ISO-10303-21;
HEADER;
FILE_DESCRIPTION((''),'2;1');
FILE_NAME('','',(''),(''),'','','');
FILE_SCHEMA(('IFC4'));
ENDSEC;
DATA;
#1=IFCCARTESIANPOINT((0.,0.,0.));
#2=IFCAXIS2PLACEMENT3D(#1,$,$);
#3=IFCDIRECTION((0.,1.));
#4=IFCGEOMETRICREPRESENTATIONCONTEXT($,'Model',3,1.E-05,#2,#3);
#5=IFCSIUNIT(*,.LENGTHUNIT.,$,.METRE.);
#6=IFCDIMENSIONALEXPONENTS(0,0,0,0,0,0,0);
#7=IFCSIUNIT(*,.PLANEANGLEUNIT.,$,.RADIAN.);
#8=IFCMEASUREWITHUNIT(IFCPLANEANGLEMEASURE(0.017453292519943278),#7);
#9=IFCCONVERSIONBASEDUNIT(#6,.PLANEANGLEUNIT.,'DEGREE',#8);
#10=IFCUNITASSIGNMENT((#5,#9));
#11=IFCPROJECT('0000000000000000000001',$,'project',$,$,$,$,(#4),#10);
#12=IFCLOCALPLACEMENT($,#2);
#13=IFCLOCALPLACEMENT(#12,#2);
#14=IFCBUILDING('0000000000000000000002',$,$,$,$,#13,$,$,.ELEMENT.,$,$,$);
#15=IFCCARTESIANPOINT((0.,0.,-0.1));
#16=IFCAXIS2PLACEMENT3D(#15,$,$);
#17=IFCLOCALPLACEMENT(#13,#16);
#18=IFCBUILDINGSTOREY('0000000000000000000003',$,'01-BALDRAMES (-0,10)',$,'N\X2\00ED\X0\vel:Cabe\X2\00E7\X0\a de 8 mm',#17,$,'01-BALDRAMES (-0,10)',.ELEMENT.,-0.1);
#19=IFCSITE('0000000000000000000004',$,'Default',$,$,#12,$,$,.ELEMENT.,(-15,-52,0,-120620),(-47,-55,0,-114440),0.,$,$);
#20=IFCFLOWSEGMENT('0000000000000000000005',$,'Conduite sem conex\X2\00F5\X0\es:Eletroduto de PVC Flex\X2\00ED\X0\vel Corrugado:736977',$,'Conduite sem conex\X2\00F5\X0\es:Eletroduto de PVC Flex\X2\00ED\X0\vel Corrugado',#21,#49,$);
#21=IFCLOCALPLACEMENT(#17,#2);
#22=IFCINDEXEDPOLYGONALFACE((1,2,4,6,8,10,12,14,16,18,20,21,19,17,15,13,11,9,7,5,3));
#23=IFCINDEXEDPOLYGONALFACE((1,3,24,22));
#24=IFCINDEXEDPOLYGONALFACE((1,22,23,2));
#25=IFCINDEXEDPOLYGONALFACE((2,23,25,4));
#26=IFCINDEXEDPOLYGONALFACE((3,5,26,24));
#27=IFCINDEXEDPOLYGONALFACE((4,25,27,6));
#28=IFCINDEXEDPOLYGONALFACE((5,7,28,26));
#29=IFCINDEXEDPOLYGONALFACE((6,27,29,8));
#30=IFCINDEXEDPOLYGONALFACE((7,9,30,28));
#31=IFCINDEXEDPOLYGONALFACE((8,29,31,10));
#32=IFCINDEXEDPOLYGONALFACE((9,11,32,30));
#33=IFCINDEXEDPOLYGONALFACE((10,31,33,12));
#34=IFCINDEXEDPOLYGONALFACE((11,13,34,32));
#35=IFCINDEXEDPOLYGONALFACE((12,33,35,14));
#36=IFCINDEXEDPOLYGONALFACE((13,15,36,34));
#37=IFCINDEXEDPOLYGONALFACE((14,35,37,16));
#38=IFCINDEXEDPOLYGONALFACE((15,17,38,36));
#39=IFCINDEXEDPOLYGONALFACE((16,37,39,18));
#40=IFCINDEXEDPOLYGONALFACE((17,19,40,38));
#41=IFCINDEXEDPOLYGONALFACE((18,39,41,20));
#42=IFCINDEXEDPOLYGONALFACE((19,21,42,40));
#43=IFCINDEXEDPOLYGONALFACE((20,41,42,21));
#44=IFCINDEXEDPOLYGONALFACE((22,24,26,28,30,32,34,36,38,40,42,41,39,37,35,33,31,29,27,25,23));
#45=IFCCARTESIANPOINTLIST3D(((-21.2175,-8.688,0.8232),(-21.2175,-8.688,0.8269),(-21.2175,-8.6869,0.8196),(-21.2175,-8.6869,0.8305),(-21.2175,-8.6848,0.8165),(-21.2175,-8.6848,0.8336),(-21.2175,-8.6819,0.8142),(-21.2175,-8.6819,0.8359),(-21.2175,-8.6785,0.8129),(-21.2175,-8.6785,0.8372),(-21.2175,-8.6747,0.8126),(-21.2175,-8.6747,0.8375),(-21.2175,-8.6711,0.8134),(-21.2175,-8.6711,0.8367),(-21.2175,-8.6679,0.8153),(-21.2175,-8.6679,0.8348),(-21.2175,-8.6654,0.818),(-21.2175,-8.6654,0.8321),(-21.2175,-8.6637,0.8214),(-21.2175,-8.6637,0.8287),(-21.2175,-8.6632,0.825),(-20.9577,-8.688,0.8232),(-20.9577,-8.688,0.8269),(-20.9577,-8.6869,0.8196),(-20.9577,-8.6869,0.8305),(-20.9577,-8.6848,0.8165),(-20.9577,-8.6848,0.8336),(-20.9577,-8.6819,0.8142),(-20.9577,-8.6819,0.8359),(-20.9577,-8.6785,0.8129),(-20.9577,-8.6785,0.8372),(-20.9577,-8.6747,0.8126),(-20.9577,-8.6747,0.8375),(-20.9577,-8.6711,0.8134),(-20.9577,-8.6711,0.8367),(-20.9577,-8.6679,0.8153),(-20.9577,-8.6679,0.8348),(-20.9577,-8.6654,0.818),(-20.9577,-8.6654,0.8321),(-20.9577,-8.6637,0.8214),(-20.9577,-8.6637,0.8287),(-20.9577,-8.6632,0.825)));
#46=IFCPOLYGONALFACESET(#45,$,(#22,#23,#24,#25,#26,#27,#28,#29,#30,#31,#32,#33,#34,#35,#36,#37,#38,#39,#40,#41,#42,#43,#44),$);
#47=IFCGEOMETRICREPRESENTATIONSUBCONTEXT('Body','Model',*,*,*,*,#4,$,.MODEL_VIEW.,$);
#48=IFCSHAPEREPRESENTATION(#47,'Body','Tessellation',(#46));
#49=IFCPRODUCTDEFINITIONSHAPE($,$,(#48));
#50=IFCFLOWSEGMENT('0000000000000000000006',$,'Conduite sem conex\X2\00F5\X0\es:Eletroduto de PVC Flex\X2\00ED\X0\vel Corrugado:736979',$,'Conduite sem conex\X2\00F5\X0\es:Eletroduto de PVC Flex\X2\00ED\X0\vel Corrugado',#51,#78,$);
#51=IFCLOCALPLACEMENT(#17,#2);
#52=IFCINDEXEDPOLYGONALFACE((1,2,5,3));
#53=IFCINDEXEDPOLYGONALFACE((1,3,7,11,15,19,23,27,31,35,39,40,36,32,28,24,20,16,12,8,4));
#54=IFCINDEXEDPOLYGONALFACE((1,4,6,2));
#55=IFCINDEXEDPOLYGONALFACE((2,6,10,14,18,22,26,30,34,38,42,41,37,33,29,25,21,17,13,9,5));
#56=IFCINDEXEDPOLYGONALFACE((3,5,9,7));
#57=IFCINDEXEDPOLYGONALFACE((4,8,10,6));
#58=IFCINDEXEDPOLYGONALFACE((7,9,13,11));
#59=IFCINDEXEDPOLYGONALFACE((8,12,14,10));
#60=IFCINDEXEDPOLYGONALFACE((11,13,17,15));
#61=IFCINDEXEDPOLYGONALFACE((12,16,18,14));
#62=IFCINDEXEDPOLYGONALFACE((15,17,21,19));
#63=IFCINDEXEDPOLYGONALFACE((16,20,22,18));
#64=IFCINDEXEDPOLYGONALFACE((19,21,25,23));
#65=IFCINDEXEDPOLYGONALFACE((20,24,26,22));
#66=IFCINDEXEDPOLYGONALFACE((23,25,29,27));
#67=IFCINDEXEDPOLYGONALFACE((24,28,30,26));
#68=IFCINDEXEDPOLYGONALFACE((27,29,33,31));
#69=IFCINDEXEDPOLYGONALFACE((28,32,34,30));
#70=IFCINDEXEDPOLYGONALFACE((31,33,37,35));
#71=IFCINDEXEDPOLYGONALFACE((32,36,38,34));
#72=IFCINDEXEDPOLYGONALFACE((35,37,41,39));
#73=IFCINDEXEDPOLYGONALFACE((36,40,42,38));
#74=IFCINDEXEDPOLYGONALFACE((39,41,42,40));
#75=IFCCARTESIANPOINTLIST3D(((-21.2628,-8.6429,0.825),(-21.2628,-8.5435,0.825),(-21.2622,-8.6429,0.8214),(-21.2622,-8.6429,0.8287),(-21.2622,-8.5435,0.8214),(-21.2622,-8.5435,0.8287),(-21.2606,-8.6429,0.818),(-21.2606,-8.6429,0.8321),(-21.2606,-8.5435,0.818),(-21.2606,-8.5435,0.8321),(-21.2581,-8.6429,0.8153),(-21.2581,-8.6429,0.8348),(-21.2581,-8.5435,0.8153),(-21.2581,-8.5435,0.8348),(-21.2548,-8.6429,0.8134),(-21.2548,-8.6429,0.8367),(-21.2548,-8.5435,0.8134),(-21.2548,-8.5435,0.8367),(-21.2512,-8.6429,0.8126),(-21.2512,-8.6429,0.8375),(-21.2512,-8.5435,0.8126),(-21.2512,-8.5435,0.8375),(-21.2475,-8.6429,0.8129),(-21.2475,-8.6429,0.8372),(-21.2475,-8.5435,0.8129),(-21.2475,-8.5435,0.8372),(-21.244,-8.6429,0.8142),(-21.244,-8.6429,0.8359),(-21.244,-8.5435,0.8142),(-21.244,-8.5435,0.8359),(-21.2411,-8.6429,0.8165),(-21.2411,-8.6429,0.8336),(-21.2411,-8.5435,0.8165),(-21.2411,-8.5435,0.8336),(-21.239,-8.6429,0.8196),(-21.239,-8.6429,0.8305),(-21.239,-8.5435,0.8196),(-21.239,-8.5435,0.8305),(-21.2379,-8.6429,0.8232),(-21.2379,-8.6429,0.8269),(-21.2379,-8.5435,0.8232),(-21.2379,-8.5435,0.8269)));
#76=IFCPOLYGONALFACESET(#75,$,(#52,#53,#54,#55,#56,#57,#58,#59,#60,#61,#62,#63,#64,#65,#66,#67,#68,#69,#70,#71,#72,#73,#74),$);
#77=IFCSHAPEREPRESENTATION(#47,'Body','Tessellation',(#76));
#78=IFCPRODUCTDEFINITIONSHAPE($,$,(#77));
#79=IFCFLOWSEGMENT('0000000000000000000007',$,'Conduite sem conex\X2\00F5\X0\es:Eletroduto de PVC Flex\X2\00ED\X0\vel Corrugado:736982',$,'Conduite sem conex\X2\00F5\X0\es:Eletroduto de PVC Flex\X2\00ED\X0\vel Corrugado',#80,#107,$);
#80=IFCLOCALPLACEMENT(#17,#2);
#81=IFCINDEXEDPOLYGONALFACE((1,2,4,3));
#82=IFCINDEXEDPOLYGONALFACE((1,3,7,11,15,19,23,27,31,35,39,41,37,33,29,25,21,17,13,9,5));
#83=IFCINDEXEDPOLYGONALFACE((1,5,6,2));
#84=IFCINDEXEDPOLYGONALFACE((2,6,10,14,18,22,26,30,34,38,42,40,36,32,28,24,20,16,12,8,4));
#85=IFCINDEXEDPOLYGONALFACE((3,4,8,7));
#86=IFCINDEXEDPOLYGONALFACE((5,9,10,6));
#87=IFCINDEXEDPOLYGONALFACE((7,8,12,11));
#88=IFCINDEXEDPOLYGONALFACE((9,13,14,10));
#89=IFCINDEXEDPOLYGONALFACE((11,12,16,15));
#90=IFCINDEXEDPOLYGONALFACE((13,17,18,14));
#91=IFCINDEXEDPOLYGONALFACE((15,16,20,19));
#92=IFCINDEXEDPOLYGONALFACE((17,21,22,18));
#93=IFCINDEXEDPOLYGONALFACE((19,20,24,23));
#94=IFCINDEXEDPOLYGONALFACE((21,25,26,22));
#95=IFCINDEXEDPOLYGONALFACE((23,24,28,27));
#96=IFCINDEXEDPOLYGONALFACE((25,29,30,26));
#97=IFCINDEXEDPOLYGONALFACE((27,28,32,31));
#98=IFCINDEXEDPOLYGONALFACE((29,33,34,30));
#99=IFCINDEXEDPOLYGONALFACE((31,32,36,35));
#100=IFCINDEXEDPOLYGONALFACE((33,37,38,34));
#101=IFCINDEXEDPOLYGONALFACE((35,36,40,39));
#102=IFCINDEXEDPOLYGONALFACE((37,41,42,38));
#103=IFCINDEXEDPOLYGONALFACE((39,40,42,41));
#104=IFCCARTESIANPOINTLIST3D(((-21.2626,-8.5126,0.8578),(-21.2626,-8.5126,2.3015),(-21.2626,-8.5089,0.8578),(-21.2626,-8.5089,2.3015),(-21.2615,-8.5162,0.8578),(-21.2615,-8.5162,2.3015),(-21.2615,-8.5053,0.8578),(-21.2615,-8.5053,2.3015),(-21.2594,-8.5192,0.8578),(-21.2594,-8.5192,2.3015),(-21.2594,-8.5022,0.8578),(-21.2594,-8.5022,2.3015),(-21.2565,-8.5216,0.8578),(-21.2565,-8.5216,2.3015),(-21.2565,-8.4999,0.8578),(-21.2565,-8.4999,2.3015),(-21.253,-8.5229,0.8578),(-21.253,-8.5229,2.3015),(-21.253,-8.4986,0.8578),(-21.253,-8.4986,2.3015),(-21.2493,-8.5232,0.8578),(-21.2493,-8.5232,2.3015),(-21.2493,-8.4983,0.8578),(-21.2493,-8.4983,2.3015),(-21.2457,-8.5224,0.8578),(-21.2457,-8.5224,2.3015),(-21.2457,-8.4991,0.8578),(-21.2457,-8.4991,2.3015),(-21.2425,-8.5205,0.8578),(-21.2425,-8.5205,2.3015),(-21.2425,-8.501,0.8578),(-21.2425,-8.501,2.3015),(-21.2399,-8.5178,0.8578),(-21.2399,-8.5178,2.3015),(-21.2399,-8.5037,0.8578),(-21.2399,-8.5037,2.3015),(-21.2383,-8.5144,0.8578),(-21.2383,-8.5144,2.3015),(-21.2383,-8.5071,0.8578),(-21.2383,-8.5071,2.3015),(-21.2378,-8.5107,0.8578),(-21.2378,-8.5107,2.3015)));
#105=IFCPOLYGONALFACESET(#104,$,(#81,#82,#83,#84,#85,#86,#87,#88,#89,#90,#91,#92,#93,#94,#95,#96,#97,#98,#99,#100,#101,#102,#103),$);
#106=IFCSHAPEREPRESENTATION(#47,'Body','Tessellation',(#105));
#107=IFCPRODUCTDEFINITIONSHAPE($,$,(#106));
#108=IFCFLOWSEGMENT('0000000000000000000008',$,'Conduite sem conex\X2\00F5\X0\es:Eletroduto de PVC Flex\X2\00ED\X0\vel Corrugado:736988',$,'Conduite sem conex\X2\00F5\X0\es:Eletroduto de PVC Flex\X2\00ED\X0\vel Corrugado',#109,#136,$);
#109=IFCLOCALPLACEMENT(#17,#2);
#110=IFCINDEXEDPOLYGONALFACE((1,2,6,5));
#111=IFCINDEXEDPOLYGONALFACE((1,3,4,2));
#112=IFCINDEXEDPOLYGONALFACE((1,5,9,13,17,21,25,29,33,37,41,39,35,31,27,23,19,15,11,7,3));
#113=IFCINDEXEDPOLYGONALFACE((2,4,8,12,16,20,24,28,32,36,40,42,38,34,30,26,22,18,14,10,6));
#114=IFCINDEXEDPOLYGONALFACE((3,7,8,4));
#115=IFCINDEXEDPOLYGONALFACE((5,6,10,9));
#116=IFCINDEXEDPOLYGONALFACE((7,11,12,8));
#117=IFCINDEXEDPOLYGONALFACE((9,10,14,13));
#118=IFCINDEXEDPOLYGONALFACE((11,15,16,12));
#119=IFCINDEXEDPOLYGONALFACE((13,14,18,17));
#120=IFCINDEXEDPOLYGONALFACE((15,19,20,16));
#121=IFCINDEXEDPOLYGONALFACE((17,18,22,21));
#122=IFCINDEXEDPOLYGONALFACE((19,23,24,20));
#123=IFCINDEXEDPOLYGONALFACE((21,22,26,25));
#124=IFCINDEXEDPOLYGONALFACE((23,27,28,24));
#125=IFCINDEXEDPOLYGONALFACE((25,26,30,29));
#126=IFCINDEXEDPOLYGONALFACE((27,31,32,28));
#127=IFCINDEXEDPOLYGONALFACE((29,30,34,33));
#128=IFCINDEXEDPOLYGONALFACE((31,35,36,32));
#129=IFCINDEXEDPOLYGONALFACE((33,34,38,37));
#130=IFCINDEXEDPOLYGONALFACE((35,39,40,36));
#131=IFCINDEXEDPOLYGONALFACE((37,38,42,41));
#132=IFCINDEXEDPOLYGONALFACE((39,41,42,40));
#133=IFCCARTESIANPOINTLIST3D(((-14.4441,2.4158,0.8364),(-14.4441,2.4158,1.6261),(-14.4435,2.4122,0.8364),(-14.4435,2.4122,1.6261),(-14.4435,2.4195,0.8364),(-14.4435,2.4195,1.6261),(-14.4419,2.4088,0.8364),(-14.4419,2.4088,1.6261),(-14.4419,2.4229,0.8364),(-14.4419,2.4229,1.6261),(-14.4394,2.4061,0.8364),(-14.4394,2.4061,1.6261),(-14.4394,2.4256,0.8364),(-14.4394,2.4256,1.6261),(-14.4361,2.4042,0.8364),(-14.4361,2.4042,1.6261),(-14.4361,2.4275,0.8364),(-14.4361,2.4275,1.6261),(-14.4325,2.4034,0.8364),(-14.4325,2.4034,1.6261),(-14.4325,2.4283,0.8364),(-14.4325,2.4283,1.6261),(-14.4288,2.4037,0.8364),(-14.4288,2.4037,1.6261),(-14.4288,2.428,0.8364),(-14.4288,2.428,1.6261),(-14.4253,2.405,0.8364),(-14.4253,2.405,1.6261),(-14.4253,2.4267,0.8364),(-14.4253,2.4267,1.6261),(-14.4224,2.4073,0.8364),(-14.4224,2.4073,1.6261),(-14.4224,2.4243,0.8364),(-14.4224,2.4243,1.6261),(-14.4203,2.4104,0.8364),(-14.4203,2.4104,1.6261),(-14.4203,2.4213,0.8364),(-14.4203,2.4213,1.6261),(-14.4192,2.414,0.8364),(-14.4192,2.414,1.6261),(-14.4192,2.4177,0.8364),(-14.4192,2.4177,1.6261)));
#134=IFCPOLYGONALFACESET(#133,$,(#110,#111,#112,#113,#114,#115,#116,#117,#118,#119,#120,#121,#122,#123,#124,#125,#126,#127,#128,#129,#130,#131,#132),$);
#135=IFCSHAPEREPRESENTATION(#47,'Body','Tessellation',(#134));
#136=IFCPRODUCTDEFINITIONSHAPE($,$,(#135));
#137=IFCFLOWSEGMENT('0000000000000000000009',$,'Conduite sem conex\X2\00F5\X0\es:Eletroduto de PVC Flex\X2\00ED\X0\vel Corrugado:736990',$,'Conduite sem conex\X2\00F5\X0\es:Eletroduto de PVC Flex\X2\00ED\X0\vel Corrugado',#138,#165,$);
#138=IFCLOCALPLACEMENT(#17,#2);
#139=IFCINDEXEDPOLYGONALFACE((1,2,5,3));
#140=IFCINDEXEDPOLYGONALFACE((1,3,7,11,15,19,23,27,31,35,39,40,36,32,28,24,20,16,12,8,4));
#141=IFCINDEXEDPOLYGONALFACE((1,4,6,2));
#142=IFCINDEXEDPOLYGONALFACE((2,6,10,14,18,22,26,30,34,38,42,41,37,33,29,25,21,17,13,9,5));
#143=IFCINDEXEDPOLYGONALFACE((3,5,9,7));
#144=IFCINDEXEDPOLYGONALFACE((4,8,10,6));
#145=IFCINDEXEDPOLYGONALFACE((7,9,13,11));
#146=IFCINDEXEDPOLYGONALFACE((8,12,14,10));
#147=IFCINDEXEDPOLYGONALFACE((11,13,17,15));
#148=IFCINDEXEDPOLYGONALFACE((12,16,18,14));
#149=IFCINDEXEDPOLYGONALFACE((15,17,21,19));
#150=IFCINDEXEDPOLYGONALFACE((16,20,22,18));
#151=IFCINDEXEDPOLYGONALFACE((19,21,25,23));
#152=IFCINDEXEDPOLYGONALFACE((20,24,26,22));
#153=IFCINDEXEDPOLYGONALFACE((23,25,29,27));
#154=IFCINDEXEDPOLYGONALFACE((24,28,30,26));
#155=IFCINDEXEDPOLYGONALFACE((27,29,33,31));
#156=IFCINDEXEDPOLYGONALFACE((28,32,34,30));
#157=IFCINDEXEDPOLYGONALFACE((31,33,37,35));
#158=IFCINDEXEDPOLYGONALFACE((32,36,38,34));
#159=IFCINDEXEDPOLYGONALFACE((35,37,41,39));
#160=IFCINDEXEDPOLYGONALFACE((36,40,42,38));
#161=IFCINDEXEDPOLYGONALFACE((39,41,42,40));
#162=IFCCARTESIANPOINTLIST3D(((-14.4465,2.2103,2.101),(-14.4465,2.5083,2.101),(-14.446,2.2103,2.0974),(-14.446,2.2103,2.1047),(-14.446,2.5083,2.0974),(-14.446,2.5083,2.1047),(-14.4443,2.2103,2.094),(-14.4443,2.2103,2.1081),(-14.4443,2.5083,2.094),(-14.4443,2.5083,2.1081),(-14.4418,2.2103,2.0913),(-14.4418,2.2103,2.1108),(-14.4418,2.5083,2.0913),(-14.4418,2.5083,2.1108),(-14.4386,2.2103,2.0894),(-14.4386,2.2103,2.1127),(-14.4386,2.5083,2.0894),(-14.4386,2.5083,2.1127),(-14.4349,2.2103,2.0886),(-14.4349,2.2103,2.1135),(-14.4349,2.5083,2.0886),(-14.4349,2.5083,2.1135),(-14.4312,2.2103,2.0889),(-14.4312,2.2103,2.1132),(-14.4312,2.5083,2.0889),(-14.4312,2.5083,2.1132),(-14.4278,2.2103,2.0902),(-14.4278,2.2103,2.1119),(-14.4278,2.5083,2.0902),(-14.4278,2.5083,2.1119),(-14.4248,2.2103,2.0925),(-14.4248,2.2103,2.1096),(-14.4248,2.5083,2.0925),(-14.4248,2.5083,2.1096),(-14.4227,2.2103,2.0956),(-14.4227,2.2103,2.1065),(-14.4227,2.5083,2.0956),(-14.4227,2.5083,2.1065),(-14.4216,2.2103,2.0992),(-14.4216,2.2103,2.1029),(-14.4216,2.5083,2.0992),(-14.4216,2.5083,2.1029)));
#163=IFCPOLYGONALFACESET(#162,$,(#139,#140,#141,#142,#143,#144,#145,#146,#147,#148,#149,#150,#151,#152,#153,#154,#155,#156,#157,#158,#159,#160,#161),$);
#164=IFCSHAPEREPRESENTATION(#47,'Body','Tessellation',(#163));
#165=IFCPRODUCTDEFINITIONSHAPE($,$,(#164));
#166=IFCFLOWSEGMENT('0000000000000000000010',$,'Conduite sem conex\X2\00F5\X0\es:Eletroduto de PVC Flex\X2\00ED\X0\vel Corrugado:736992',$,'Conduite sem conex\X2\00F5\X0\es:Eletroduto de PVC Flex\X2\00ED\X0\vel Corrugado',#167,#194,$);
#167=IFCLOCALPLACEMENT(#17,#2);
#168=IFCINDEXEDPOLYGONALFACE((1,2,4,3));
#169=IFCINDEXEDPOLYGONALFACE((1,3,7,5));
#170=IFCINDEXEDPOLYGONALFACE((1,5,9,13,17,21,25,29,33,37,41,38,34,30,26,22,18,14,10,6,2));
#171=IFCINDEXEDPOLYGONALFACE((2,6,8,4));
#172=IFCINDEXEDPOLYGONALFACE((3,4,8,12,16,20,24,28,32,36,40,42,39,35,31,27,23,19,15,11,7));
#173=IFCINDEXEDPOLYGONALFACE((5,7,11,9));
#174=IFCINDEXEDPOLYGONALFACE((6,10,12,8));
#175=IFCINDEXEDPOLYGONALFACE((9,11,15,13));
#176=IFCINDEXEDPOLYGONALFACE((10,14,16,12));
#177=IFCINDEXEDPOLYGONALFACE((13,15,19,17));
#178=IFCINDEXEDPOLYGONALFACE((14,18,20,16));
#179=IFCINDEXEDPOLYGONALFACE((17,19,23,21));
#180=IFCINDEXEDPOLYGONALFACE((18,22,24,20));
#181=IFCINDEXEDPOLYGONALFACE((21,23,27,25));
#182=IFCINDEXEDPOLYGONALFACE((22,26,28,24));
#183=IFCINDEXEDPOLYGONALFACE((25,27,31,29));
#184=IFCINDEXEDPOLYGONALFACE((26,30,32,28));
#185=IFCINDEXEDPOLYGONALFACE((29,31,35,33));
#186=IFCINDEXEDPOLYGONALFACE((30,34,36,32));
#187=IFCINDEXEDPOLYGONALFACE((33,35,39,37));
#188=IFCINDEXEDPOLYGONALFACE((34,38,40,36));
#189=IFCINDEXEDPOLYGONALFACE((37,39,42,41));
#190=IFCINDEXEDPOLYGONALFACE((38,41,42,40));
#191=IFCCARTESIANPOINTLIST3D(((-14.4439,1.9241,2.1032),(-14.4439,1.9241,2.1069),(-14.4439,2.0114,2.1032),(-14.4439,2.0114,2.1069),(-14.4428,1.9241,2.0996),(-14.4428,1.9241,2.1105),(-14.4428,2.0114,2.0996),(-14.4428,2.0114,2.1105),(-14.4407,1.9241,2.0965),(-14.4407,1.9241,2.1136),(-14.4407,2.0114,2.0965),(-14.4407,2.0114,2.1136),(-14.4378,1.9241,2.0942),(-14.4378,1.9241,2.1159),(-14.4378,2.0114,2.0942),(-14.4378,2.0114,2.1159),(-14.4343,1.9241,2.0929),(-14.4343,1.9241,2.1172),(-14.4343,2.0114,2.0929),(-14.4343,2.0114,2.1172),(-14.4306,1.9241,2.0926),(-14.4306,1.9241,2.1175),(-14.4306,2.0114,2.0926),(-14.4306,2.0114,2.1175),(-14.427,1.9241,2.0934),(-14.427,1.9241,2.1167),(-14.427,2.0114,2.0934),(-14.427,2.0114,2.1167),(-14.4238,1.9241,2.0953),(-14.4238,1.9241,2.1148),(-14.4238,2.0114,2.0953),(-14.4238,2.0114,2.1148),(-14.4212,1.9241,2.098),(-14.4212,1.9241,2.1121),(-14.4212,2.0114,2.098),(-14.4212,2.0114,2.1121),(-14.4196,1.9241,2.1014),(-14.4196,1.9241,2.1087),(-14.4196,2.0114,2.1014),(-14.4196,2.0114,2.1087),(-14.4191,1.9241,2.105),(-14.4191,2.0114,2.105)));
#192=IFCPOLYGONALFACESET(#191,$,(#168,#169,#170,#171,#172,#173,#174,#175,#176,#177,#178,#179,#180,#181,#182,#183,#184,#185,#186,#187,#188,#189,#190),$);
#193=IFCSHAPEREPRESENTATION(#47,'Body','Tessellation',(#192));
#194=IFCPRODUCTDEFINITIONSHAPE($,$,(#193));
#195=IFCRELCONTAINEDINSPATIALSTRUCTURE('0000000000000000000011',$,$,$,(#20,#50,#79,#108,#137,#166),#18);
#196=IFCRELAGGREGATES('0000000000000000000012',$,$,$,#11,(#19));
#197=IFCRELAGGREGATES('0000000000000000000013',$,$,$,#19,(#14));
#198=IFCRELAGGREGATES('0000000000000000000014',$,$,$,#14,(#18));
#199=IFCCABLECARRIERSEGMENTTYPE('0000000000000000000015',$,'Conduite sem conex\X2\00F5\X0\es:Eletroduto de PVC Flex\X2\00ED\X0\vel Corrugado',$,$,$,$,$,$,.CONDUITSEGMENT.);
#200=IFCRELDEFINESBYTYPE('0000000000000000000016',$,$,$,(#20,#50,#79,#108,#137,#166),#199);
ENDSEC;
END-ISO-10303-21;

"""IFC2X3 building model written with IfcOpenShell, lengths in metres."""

from ifc_helpers import new_model, entity, si_unit, converted_unit, direction, frame, frame_2d, origin, origin_2d_with_axis, place, context, subcontext, project, spatial, circle, extrude, type_object, element, save


model = new_model("IFC2X3")

# Units and contexts
model_context = context("Model", 3, precision=1e-05, world=origin(), true_north=direction((0.0, 1.0)))
body_context = subcontext(model_context, "Body", "Model", "MODEL_VIEW")
ifc_project = project(units=[si_unit("LENGTHUNIT", "METRE"), converted_unit("PLANEANGLEUNIT", "DEGREE", entity("IfcPlaneAngleMeasure", 0.017453292519943278), si_unit("PLANEANGLEUNIT", "RADIAN"), dimensions=[0, 0, 0, 0, 0, 0, 0])], contexts=[model_context])

# Site, building, storey
site_placement = place(None, origin())
site = spatial("IfcSite", under=ifc_project, at=site_placement, Name="Default", CompositionType="ELEMENT", RefLatitude=(-15, -52, 0, -120620), RefLongitude=(-47, -55, 0, -114440), RefElevation=0.0)
building_placement = place(site_placement, origin())
building = spatial("IfcBuilding", under=site, at=building_placement, CompositionType="ELEMENT")
storey_placement = place(building_placement, frame((0.0, 0.0, -0.1)))
storey = spatial("IfcBuildingStorey", under=building, at=storey_placement, Name="01-BALDRAMES (-0,10)", ObjectType="Nível:Cabeça de 8 mm", LongName="01-BALDRAMES (-0,10)", CompositionType="ELEMENT", Elevation=-0.1)

# Flow segments
cable_carrier_segment_type = type_object("IfcCableCarrierSegmentType", Name="Conduite sem conexões:Eletroduto de PVC Flexível Corrugado", PredefinedType="CONDUITSEGMENT")
flow_segment_1_placement = place(storey_placement, origin())
element("IfcFlowSegment", 1, at=flow_segment_1_placement, inside=storey, type_object=cable_carrier_segment_type, Name="Conduite sem conexões:Eletroduto de PVC Flexível Corrugado:736977", ObjectType="Conduite sem conexões:Eletroduto de PVC Flexível Corrugado", context=body_context, shape_type="SweptSolid", body=[
    extrude(circle(Radius=0.0125, at=frame_2d((0.0, 0.0), x_axis=(1.0, 0.0))), frame((-21.2175, -8.6757, 0.825), z_axis=(1.0, 0.0, 0.0), x_axis=(0.0, 1.0, 0.0)), (0.0, 0.0, 1.0), 0.2597),
])
flow_segment_2_placement = place(storey_placement, origin())
element("IfcFlowSegment", 2, at=flow_segment_2_placement, inside=storey, type_object=cable_carrier_segment_type, Name="Conduite sem conexões:Eletroduto de PVC Flexível Corrugado:736979", ObjectType="Conduite sem conexões:Eletroduto de PVC Flexível Corrugado", context=body_context, shape_type="SweptSolid", body=[
    extrude(circle(Radius=0.0125, at=frame_2d((0.0, 0.0), x_axis=(1.0, 0.0))), frame((-21.2503, -8.6429, 0.825), z_axis=(0.0, 1.0, 0.0), x_axis=(-1.0, 0.0, 0.0)), (0.0, 0.0, 1.0), 0.0993),
])
flow_segment_3_placement = place(storey_placement, origin())
element("IfcFlowSegment", 3, at=flow_segment_3_placement, inside=storey, type_object=cable_carrier_segment_type, Name="Conduite sem conexões:Eletroduto de PVC Flexível Corrugado:736982", ObjectType="Conduite sem conexões:Eletroduto de PVC Flexível Corrugado", context=body_context, shape_type="SweptSolid", body=[
    extrude(circle(Radius=0.0125, at=frame_2d((0.0, 0.0), x_axis=(1.0, 0.0))), frame((-21.2503, -8.5107, 0.8578)), (0.0, 0.0, 1.0), 1.4437),
])
flow_segment_4_placement = place(storey_placement, origin())
element("IfcFlowSegment", 4, at=flow_segment_4_placement, inside=storey, type_object=cable_carrier_segment_type, Name="Conduite sem conexões:Eletroduto de PVC Flexível Corrugado:736988", ObjectType="Conduite sem conexões:Eletroduto de PVC Flexível Corrugado", context=body_context, shape_type="SweptSolid", body=[
    extrude(circle(Radius=0.0125, at=frame_2d((0.0, 0.0), x_axis=(1.0, 0.0))), frame((-14.4316, 2.4158, 0.8364), z_axis=(0.0, 0.0, 1.0), x_axis=(-1.0, 0.0, 0.0)), (0.0, 0.0, 1.0), 0.7897),
])
flow_segment_5_placement = place(storey_placement, origin())
element("IfcFlowSegment", 5, at=flow_segment_5_placement, inside=storey, type_object=cable_carrier_segment_type, Name="Conduite sem conexões:Eletroduto de PVC Flexível Corrugado:736990", ObjectType="Conduite sem conexões:Eletroduto de PVC Flexível Corrugado", context=body_context, shape_type="SweptSolid", body=[
    extrude(circle(Radius=0.0125, at=frame_2d((0.0, 0.0), x_axis=(1.0, 0.0))), frame((-14.434, 2.2103, 2.101), z_axis=(0.0, 1.0, 0.0), x_axis=(-1.0, 0.0, 0.0)), (0.0, 0.0, 1.0), 0.298),
])
flow_segment_6_placement = place(storey_placement, origin())
element("IfcFlowSegment", 6, at=flow_segment_6_placement, inside=storey, type_object=cable_carrier_segment_type, Name="Conduite sem conexões:Eletroduto de PVC Flexível Corrugado:736992", ObjectType="Conduite sem conexões:Eletroduto de PVC Flexível Corrugado", context=body_context, shape_type="SweptSolid", body=[
    extrude(circle(Radius=0.0125, at=origin_2d_with_axis()), frame((-14.4316, 1.9241, 2.105), z_axis=(0.0, 1.0, 0.0), x_axis=(1.0, 0.0, 0.0)), (0.0, 0.0, 1.0), 0.0873),
])

save(model, "model.ifc")
